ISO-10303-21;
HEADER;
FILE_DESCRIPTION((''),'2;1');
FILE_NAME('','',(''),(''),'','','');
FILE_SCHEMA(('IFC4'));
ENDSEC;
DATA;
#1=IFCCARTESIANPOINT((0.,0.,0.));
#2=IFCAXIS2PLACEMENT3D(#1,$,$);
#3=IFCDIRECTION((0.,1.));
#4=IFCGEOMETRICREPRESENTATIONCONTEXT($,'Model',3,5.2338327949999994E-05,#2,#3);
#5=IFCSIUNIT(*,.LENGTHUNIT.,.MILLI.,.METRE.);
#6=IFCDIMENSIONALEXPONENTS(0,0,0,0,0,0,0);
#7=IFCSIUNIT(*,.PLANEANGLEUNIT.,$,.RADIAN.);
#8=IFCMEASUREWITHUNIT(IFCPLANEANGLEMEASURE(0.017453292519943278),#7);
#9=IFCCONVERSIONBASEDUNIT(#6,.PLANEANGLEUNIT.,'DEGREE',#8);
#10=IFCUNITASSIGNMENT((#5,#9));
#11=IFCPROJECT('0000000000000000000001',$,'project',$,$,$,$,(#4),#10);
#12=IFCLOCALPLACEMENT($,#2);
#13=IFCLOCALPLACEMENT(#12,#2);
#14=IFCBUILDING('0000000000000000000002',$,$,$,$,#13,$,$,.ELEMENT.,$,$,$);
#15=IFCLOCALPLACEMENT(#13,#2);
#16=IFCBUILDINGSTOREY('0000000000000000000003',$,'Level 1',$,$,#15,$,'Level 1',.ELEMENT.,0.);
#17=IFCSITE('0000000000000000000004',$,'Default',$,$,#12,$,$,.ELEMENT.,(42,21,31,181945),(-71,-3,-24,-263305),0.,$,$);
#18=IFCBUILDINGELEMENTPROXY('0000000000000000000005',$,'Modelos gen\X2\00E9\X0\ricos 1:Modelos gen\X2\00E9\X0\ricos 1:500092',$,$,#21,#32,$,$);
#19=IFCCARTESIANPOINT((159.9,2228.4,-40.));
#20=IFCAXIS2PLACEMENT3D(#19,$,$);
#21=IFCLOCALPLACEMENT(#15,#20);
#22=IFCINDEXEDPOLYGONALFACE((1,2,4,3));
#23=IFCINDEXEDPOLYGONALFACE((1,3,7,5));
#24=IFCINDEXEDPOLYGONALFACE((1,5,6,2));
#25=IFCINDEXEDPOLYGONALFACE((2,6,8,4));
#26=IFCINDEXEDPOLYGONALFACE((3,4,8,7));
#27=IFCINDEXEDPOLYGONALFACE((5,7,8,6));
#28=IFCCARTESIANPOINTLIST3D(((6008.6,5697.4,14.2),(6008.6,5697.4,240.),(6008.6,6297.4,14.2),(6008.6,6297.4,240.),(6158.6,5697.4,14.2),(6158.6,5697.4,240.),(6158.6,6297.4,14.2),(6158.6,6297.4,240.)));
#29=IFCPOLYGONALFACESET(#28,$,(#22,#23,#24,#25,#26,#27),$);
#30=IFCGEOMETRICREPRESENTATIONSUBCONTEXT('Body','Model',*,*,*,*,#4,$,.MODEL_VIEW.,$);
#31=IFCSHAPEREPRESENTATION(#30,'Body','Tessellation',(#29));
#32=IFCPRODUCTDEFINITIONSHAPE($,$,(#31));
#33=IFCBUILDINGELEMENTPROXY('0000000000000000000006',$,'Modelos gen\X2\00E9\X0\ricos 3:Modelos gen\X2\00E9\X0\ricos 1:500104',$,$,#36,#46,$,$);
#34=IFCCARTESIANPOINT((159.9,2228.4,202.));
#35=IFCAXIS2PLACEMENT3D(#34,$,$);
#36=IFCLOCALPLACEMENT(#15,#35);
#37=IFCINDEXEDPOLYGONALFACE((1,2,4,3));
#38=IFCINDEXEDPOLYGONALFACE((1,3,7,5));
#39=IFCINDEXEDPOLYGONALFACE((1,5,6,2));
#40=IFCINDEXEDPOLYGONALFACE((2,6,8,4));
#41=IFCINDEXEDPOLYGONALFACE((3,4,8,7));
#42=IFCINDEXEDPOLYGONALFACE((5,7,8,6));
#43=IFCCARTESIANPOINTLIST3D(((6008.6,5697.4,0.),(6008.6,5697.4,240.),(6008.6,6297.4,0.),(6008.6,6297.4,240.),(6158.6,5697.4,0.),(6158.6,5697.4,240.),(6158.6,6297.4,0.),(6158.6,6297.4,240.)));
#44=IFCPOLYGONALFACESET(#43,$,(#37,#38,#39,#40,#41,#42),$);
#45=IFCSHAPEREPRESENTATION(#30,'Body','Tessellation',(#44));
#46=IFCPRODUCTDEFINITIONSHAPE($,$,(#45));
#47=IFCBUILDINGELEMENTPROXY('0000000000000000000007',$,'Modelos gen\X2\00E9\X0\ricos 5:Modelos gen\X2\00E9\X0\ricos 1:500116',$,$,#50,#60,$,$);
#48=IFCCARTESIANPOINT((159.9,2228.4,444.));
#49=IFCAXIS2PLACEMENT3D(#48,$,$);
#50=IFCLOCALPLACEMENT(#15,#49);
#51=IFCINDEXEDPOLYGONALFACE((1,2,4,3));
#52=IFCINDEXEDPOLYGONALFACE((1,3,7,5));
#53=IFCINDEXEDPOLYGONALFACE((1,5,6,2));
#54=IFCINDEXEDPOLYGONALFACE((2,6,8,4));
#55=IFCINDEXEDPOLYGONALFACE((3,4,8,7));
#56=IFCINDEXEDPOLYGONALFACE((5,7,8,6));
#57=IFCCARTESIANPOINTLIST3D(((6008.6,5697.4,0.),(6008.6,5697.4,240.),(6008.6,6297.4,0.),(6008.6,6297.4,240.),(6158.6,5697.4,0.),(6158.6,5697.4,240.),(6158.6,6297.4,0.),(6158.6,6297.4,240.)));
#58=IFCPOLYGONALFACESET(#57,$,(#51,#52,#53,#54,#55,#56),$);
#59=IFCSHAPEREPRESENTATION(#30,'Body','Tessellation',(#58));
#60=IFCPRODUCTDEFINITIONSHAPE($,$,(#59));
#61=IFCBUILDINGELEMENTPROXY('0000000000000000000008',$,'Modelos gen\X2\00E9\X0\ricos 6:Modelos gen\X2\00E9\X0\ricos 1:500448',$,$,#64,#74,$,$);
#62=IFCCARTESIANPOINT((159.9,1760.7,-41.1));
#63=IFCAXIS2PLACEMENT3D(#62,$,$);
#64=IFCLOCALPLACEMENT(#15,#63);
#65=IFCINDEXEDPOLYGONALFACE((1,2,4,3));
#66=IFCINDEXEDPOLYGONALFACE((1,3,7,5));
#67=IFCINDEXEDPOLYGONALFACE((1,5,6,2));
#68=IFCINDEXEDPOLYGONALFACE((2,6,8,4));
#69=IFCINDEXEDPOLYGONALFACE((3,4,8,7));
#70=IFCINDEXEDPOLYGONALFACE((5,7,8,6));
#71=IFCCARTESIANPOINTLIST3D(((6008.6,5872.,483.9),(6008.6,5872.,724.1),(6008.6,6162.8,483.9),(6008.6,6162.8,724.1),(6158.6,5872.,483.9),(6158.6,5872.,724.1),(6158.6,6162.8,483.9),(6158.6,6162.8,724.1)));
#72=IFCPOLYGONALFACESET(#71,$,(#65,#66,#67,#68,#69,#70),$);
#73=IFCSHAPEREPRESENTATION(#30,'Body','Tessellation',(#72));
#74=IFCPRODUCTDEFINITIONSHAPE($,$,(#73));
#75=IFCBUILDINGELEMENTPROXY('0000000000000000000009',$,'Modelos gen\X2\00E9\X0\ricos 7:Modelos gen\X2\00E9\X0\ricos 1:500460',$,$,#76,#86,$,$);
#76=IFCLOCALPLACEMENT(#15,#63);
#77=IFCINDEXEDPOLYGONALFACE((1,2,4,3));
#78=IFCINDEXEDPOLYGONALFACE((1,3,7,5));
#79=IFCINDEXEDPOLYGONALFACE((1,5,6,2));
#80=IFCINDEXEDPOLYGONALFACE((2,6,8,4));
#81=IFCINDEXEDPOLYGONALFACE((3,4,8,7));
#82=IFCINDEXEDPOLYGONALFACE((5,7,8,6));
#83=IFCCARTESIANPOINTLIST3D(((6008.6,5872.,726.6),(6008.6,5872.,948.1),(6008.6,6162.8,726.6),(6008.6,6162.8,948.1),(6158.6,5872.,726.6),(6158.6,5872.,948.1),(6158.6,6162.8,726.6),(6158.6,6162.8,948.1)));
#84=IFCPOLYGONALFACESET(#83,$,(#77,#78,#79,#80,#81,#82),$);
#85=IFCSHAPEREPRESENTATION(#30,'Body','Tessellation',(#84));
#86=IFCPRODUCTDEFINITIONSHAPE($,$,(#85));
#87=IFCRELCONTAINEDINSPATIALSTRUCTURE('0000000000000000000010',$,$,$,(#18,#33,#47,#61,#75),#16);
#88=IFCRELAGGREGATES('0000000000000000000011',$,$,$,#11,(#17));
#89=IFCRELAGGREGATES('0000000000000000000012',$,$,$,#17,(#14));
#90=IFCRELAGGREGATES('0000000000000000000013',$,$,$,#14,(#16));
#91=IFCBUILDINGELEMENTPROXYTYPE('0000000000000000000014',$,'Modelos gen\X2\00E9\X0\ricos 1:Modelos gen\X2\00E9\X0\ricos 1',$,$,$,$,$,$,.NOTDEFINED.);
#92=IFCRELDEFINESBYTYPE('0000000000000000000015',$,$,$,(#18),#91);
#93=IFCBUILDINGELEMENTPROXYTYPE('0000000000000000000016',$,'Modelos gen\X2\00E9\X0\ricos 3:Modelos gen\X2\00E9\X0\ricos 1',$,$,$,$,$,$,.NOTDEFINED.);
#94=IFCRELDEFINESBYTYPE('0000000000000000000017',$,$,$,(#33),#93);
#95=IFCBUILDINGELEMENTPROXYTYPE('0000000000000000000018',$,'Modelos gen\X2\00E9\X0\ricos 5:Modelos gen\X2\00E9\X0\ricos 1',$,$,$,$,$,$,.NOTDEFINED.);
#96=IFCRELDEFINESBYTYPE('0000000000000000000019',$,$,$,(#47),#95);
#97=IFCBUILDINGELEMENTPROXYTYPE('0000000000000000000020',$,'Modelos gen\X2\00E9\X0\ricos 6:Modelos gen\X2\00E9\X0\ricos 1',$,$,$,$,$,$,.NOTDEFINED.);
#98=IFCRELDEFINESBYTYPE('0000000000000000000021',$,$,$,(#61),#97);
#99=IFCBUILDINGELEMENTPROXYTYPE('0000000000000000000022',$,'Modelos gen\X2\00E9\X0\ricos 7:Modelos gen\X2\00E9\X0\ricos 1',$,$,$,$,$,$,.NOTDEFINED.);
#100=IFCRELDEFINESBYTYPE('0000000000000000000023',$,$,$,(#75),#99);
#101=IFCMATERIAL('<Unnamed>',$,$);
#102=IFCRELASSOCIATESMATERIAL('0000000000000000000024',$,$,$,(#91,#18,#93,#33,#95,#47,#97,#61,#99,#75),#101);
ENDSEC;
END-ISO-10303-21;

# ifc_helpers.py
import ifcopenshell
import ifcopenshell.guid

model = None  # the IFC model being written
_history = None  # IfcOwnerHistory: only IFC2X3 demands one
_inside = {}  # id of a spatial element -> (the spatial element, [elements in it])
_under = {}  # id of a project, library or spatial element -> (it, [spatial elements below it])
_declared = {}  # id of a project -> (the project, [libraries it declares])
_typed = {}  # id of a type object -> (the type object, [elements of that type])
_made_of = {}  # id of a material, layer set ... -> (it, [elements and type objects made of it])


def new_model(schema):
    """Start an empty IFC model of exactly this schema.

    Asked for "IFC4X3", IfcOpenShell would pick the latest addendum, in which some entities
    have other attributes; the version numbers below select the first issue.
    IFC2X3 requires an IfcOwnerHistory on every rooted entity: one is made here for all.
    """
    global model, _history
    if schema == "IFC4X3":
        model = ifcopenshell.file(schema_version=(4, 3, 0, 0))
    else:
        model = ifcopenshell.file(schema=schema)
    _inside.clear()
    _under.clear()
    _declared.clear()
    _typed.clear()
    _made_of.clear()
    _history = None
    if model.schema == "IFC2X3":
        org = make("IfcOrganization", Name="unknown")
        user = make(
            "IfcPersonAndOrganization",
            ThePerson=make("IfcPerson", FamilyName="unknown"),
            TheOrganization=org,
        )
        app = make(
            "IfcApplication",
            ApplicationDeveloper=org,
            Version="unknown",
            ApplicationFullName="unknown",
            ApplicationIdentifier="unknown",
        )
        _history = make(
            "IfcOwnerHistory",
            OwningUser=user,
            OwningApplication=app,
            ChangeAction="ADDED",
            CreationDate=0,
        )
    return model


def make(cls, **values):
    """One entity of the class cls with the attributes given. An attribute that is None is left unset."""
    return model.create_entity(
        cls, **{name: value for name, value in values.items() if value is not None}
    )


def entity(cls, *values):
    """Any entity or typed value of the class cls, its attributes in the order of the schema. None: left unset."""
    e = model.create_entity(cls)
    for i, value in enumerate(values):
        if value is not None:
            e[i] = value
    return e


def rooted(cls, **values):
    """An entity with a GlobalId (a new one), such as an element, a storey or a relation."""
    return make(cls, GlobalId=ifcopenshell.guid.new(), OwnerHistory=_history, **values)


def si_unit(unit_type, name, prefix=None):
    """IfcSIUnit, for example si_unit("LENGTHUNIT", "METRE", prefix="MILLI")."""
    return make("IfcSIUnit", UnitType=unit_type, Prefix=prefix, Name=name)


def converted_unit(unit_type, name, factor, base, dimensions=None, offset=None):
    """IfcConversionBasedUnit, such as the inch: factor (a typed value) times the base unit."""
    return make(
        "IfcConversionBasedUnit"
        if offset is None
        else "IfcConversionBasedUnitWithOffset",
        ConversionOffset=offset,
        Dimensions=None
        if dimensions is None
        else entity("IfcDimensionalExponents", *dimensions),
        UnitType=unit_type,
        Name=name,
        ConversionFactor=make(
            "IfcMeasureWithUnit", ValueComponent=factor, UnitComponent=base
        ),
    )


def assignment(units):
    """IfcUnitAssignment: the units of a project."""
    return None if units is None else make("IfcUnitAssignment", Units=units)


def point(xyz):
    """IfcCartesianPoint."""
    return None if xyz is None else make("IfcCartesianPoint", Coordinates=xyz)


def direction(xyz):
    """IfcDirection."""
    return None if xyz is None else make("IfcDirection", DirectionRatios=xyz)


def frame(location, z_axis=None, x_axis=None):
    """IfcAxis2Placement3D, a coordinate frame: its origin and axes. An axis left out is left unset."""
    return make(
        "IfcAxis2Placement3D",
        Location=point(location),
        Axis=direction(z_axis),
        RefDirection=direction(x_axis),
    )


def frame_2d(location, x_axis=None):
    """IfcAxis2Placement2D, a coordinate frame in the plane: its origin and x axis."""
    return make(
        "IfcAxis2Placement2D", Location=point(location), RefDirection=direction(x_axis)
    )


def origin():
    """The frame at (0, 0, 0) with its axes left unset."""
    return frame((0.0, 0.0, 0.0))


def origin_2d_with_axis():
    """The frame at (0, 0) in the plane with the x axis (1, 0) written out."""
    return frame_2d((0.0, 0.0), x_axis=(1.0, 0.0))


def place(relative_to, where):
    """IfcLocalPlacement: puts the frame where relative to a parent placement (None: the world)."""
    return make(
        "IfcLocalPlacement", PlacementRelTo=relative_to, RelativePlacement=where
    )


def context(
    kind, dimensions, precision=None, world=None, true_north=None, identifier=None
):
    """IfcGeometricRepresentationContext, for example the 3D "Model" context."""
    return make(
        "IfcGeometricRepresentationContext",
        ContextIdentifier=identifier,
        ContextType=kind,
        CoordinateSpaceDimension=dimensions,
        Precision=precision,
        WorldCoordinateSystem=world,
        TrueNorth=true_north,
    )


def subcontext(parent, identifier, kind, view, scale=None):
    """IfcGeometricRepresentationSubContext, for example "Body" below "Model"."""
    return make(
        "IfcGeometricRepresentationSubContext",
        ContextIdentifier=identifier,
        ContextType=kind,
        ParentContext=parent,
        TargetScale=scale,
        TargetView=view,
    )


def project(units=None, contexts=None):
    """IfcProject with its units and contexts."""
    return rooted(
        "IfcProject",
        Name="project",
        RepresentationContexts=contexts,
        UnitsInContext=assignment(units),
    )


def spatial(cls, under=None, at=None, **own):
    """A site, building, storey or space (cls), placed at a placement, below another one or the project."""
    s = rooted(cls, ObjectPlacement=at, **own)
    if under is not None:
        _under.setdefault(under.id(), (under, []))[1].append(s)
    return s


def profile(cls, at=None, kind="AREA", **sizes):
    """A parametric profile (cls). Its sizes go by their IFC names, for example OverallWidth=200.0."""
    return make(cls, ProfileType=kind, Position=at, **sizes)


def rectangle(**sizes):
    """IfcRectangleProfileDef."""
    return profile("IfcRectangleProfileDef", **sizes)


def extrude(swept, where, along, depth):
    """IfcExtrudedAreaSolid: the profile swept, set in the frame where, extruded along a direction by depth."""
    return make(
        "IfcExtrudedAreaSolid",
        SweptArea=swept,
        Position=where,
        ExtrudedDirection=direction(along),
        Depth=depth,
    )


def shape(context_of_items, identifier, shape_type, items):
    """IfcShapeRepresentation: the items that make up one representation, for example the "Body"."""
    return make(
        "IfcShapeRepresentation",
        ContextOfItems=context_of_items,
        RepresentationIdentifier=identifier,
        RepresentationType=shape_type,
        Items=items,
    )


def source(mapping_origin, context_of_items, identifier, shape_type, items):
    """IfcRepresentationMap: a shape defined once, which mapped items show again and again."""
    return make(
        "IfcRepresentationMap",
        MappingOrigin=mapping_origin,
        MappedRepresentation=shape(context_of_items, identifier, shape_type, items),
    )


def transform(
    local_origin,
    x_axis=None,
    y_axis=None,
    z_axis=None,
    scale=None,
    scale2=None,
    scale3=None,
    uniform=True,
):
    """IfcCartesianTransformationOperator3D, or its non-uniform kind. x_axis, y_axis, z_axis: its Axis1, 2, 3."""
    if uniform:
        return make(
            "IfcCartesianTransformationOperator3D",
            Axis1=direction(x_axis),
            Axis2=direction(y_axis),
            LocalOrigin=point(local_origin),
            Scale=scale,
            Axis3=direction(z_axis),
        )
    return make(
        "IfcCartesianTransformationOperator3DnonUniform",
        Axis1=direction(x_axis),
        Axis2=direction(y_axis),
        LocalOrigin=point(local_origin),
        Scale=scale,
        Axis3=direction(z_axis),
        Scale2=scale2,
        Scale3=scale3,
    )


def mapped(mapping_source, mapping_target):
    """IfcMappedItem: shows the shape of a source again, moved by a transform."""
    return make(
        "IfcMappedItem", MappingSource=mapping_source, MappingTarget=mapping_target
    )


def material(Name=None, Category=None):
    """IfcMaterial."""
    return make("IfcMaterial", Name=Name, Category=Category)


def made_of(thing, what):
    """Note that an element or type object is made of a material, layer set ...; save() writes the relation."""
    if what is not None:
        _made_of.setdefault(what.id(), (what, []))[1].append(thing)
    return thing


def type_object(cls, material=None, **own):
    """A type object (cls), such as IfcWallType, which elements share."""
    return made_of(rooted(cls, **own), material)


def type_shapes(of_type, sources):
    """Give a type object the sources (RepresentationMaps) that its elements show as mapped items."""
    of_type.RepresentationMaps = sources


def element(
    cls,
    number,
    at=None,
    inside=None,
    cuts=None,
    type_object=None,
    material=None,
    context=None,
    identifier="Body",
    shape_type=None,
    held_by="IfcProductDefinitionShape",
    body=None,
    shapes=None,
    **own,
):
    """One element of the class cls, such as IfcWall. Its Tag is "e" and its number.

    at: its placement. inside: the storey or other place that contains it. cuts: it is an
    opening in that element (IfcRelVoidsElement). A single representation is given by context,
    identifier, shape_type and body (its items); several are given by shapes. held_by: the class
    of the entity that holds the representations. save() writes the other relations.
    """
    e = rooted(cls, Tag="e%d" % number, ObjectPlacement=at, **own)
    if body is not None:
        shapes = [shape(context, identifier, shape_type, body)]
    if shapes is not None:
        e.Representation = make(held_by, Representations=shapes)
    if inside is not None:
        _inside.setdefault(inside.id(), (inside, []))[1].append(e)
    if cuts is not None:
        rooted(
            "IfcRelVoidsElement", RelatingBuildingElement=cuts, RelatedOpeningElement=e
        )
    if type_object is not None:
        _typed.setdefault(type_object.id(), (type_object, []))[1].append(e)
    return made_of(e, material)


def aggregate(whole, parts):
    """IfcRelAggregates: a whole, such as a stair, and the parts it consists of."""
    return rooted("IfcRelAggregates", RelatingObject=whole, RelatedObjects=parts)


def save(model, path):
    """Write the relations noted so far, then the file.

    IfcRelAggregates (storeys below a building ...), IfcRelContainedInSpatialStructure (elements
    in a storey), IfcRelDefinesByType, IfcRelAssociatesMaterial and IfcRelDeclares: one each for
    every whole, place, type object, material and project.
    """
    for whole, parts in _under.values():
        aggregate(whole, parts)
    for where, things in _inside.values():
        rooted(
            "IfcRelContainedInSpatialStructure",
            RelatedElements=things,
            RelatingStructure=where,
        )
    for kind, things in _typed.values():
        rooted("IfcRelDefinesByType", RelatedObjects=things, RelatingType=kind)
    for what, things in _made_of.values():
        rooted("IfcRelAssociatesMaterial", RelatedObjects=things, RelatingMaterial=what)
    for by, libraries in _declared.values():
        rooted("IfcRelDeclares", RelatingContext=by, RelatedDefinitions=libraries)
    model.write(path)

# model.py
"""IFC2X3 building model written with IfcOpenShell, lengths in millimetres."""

from ifc_helpers import new_model, entity, si_unit, converted_unit, direction, frame, frame_2d, origin, origin_2d_with_axis, place, context, subcontext, project, spatial, rectangle, extrude, source, transform, mapped, material, type_object, type_shapes, element, save


model = new_model("IFC2X3")

# Units and contexts
model_context = context("Model", 3, precision=5.2338327949999994e-05, world=origin(), true_north=direction((0.0, 1.0)))
body_context = subcontext(model_context, "Body", "Model", "MODEL_VIEW")
ifc_project = project(units=[si_unit("LENGTHUNIT", "METRE", prefix="MILLI"), converted_unit("PLANEANGLEUNIT", "DEGREE", entity("IfcPlaneAngleMeasure", 0.017453292519943278), si_unit("PLANEANGLEUNIT", "RADIAN"), dimensions=[0, 0, 0, 0, 0, 0, 0])], contexts=[model_context])

# Site, building, storey
site_placement = place(None, origin())
site = spatial("IfcSite", under=ifc_project, at=site_placement, Name="Default", CompositionType="ELEMENT", RefLatitude=(42, 21, 31, 181945), RefLongitude=(-71, -3, -24, -263305), RefElevation=0.0)
building_placement = place(site_placement, origin())
building = spatial("IfcBuilding", under=site, at=building_placement, CompositionType="ELEMENT")
storey_placement = place(building_placement, origin())
storey = spatial("IfcBuildingStorey", under=building, at=storey_placement, Name="Level 1", LongName="Level 1", CompositionType="ELEMENT", Elevation=0.0)

# Building element proxies
ifc_material_1 = material(Name="<Unnamed>")
building_element_proxy_type_1 = type_object("IfcBuildingElementProxyType", Name="Modelos genéricos 1:Modelos genéricos 1", PredefinedType="NOTDEFINED", material=ifc_material_1)
shared_shape_1 = source(origin(), body_context, "Body", "SweptSolid", [
    extrude(rectangle(XDim=150.0, YDim=600.0, at=origin_2d_with_axis()), frame((6083.6, 5997.4, 14.2), z_axis=(0.0, 0.0, 1.0), x_axis=(-1.0, 0.0, 0.0)), (0.0, 0.0, 1.0), 225.8),
])
type_shapes(building_element_proxy_type_1, [shared_shape_1])
proxy_1_placement = place(storey_placement, frame((159.9, 2228.4, -40.0)))
element("IfcBuildingElementProxy", 1, at=proxy_1_placement, inside=storey, type_object=building_element_proxy_type_1, material=ifc_material_1, Name="Modelos genéricos 1:Modelos genéricos 1:500092", context=body_context, shape_type="MappedRepresentation", body=[
    mapped(shared_shape_1, transform((0.0, 0.0, 0.0), scale=1.0)),
])
building_element_proxy_type_2 = type_object("IfcBuildingElementProxyType", Name="Modelos genéricos 3:Modelos genéricos 1", PredefinedType="NOTDEFINED", material=ifc_material_1)
shared_shape_2 = source(origin(), body_context, "Body", "SweptSolid", [
    extrude(rectangle(XDim=150.0, YDim=600.0, at=origin_2d_with_axis()), frame((6083.6, 5997.4, 0.0), z_axis=(0.0, 0.0, 1.0), x_axis=(-1.0, 0.0, 0.0)), (0.0, 0.0, 1.0), 240.0),
])
type_shapes(building_element_proxy_type_2, [shared_shape_2])
proxy_2_placement = place(storey_placement, frame((159.9, 2228.4, 202.0)))
element("IfcBuildingElementProxy", 2, at=proxy_2_placement, inside=storey, type_object=building_element_proxy_type_2, material=ifc_material_1, Name="Modelos genéricos 3:Modelos genéricos 1:500104", context=body_context, shape_type="MappedRepresentation", body=[
    mapped(shared_shape_2, transform((0.0, 0.0, 0.0), scale=1.0)),
])
building_element_proxy_type_3 = type_object("IfcBuildingElementProxyType", Name="Modelos genéricos 5:Modelos genéricos 1", PredefinedType="NOTDEFINED", material=ifc_material_1)
shared_shape_3 = source(origin(), body_context, "Body", "SweptSolid", [
    extrude(rectangle(XDim=150.0, YDim=600.0, at=origin_2d_with_axis()), frame((6083.6, 5997.4, 0.0), z_axis=(0.0, 0.0, 1.0), x_axis=(-1.0, 0.0, 0.0)), (0.0, 0.0, 1.0), 240.0),
])
type_shapes(building_element_proxy_type_3, [shared_shape_3])
proxy_3_placement = place(storey_placement, frame((159.9, 2228.4, 444.0)))
element("IfcBuildingElementProxy", 3, at=proxy_3_placement, inside=storey, type_object=building_element_proxy_type_3, material=ifc_material_1, Name="Modelos genéricos 5:Modelos genéricos 1:500116", context=body_context, shape_type="MappedRepresentation", body=[
    mapped(shared_shape_3, transform((0.0, 0.0, 0.0), scale=1.0)),
])
building_element_proxy_type_4 = type_object("IfcBuildingElementProxyType", Name="Modelos genéricos 6:Modelos genéricos 1", PredefinedType="NOTDEFINED", material=ifc_material_1)
shared_shape_4 = source(origin(), body_context, "Body", "SweptSolid", [
    extrude(rectangle(XDim=150.0, YDim=290.8, at=frame_2d((0.0, 0.0), x_axis=(1.0, 0.0))), frame((6083.6, 6017.4, 483.9), z_axis=(0.0, 0.0, 1.0), x_axis=(-1.0, 0.0, 0.0)), (0.0, 0.0, 1.0), 240.2),
])
type_shapes(building_element_proxy_type_4, [shared_shape_4])
proxy_4_placement = place(storey_placement, frame((159.9, 1760.7, -41.1)))
element("IfcBuildingElementProxy", 4, at=proxy_4_placement, inside=storey, type_object=building_element_proxy_type_4, material=ifc_material_1, Name="Modelos genéricos 6:Modelos genéricos 1:500448", context=body_context, shape_type="MappedRepresentation", body=[
    mapped(shared_shape_4, transform((0.0, 0.0, 0.0), scale=1.0)),
])
building_element_proxy_type_5 = type_object("IfcBuildingElementProxyType", Name="Modelos genéricos 7:Modelos genéricos 1", PredefinedType="NOTDEFINED", material=ifc_material_1)
shared_shape_5 = source(origin(), body_context, "Body", "SweptSolid", [
    extrude(rectangle(XDim=150.0, YDim=290.8, at=frame_2d((0.0, 0.0), x_axis=(1.0, 0.0))), frame((6083.6, 6017.4, 726.6), z_axis=(0.0, 0.0, 1.0), x_axis=(-1.0, 0.0, 0.0)), (0.0, 0.0, 1.0), 221.5),
])
type_shapes(building_element_proxy_type_5, [shared_shape_5])
proxy_5_placement = place(storey_placement, frame((159.9, 1760.7, -41.1)))
element("IfcBuildingElementProxy", 5, at=proxy_5_placement, inside=storey, type_object=building_element_proxy_type_5, material=ifc_material_1, Name="Modelos genéricos 7:Modelos genéricos 1:500460", context=body_context, shape_type="MappedRepresentation", body=[
    mapped(shared_shape_5, transform((0.0, 0.0, 0.0), scale=1.0)),
])

save(model, "model.ifc")
